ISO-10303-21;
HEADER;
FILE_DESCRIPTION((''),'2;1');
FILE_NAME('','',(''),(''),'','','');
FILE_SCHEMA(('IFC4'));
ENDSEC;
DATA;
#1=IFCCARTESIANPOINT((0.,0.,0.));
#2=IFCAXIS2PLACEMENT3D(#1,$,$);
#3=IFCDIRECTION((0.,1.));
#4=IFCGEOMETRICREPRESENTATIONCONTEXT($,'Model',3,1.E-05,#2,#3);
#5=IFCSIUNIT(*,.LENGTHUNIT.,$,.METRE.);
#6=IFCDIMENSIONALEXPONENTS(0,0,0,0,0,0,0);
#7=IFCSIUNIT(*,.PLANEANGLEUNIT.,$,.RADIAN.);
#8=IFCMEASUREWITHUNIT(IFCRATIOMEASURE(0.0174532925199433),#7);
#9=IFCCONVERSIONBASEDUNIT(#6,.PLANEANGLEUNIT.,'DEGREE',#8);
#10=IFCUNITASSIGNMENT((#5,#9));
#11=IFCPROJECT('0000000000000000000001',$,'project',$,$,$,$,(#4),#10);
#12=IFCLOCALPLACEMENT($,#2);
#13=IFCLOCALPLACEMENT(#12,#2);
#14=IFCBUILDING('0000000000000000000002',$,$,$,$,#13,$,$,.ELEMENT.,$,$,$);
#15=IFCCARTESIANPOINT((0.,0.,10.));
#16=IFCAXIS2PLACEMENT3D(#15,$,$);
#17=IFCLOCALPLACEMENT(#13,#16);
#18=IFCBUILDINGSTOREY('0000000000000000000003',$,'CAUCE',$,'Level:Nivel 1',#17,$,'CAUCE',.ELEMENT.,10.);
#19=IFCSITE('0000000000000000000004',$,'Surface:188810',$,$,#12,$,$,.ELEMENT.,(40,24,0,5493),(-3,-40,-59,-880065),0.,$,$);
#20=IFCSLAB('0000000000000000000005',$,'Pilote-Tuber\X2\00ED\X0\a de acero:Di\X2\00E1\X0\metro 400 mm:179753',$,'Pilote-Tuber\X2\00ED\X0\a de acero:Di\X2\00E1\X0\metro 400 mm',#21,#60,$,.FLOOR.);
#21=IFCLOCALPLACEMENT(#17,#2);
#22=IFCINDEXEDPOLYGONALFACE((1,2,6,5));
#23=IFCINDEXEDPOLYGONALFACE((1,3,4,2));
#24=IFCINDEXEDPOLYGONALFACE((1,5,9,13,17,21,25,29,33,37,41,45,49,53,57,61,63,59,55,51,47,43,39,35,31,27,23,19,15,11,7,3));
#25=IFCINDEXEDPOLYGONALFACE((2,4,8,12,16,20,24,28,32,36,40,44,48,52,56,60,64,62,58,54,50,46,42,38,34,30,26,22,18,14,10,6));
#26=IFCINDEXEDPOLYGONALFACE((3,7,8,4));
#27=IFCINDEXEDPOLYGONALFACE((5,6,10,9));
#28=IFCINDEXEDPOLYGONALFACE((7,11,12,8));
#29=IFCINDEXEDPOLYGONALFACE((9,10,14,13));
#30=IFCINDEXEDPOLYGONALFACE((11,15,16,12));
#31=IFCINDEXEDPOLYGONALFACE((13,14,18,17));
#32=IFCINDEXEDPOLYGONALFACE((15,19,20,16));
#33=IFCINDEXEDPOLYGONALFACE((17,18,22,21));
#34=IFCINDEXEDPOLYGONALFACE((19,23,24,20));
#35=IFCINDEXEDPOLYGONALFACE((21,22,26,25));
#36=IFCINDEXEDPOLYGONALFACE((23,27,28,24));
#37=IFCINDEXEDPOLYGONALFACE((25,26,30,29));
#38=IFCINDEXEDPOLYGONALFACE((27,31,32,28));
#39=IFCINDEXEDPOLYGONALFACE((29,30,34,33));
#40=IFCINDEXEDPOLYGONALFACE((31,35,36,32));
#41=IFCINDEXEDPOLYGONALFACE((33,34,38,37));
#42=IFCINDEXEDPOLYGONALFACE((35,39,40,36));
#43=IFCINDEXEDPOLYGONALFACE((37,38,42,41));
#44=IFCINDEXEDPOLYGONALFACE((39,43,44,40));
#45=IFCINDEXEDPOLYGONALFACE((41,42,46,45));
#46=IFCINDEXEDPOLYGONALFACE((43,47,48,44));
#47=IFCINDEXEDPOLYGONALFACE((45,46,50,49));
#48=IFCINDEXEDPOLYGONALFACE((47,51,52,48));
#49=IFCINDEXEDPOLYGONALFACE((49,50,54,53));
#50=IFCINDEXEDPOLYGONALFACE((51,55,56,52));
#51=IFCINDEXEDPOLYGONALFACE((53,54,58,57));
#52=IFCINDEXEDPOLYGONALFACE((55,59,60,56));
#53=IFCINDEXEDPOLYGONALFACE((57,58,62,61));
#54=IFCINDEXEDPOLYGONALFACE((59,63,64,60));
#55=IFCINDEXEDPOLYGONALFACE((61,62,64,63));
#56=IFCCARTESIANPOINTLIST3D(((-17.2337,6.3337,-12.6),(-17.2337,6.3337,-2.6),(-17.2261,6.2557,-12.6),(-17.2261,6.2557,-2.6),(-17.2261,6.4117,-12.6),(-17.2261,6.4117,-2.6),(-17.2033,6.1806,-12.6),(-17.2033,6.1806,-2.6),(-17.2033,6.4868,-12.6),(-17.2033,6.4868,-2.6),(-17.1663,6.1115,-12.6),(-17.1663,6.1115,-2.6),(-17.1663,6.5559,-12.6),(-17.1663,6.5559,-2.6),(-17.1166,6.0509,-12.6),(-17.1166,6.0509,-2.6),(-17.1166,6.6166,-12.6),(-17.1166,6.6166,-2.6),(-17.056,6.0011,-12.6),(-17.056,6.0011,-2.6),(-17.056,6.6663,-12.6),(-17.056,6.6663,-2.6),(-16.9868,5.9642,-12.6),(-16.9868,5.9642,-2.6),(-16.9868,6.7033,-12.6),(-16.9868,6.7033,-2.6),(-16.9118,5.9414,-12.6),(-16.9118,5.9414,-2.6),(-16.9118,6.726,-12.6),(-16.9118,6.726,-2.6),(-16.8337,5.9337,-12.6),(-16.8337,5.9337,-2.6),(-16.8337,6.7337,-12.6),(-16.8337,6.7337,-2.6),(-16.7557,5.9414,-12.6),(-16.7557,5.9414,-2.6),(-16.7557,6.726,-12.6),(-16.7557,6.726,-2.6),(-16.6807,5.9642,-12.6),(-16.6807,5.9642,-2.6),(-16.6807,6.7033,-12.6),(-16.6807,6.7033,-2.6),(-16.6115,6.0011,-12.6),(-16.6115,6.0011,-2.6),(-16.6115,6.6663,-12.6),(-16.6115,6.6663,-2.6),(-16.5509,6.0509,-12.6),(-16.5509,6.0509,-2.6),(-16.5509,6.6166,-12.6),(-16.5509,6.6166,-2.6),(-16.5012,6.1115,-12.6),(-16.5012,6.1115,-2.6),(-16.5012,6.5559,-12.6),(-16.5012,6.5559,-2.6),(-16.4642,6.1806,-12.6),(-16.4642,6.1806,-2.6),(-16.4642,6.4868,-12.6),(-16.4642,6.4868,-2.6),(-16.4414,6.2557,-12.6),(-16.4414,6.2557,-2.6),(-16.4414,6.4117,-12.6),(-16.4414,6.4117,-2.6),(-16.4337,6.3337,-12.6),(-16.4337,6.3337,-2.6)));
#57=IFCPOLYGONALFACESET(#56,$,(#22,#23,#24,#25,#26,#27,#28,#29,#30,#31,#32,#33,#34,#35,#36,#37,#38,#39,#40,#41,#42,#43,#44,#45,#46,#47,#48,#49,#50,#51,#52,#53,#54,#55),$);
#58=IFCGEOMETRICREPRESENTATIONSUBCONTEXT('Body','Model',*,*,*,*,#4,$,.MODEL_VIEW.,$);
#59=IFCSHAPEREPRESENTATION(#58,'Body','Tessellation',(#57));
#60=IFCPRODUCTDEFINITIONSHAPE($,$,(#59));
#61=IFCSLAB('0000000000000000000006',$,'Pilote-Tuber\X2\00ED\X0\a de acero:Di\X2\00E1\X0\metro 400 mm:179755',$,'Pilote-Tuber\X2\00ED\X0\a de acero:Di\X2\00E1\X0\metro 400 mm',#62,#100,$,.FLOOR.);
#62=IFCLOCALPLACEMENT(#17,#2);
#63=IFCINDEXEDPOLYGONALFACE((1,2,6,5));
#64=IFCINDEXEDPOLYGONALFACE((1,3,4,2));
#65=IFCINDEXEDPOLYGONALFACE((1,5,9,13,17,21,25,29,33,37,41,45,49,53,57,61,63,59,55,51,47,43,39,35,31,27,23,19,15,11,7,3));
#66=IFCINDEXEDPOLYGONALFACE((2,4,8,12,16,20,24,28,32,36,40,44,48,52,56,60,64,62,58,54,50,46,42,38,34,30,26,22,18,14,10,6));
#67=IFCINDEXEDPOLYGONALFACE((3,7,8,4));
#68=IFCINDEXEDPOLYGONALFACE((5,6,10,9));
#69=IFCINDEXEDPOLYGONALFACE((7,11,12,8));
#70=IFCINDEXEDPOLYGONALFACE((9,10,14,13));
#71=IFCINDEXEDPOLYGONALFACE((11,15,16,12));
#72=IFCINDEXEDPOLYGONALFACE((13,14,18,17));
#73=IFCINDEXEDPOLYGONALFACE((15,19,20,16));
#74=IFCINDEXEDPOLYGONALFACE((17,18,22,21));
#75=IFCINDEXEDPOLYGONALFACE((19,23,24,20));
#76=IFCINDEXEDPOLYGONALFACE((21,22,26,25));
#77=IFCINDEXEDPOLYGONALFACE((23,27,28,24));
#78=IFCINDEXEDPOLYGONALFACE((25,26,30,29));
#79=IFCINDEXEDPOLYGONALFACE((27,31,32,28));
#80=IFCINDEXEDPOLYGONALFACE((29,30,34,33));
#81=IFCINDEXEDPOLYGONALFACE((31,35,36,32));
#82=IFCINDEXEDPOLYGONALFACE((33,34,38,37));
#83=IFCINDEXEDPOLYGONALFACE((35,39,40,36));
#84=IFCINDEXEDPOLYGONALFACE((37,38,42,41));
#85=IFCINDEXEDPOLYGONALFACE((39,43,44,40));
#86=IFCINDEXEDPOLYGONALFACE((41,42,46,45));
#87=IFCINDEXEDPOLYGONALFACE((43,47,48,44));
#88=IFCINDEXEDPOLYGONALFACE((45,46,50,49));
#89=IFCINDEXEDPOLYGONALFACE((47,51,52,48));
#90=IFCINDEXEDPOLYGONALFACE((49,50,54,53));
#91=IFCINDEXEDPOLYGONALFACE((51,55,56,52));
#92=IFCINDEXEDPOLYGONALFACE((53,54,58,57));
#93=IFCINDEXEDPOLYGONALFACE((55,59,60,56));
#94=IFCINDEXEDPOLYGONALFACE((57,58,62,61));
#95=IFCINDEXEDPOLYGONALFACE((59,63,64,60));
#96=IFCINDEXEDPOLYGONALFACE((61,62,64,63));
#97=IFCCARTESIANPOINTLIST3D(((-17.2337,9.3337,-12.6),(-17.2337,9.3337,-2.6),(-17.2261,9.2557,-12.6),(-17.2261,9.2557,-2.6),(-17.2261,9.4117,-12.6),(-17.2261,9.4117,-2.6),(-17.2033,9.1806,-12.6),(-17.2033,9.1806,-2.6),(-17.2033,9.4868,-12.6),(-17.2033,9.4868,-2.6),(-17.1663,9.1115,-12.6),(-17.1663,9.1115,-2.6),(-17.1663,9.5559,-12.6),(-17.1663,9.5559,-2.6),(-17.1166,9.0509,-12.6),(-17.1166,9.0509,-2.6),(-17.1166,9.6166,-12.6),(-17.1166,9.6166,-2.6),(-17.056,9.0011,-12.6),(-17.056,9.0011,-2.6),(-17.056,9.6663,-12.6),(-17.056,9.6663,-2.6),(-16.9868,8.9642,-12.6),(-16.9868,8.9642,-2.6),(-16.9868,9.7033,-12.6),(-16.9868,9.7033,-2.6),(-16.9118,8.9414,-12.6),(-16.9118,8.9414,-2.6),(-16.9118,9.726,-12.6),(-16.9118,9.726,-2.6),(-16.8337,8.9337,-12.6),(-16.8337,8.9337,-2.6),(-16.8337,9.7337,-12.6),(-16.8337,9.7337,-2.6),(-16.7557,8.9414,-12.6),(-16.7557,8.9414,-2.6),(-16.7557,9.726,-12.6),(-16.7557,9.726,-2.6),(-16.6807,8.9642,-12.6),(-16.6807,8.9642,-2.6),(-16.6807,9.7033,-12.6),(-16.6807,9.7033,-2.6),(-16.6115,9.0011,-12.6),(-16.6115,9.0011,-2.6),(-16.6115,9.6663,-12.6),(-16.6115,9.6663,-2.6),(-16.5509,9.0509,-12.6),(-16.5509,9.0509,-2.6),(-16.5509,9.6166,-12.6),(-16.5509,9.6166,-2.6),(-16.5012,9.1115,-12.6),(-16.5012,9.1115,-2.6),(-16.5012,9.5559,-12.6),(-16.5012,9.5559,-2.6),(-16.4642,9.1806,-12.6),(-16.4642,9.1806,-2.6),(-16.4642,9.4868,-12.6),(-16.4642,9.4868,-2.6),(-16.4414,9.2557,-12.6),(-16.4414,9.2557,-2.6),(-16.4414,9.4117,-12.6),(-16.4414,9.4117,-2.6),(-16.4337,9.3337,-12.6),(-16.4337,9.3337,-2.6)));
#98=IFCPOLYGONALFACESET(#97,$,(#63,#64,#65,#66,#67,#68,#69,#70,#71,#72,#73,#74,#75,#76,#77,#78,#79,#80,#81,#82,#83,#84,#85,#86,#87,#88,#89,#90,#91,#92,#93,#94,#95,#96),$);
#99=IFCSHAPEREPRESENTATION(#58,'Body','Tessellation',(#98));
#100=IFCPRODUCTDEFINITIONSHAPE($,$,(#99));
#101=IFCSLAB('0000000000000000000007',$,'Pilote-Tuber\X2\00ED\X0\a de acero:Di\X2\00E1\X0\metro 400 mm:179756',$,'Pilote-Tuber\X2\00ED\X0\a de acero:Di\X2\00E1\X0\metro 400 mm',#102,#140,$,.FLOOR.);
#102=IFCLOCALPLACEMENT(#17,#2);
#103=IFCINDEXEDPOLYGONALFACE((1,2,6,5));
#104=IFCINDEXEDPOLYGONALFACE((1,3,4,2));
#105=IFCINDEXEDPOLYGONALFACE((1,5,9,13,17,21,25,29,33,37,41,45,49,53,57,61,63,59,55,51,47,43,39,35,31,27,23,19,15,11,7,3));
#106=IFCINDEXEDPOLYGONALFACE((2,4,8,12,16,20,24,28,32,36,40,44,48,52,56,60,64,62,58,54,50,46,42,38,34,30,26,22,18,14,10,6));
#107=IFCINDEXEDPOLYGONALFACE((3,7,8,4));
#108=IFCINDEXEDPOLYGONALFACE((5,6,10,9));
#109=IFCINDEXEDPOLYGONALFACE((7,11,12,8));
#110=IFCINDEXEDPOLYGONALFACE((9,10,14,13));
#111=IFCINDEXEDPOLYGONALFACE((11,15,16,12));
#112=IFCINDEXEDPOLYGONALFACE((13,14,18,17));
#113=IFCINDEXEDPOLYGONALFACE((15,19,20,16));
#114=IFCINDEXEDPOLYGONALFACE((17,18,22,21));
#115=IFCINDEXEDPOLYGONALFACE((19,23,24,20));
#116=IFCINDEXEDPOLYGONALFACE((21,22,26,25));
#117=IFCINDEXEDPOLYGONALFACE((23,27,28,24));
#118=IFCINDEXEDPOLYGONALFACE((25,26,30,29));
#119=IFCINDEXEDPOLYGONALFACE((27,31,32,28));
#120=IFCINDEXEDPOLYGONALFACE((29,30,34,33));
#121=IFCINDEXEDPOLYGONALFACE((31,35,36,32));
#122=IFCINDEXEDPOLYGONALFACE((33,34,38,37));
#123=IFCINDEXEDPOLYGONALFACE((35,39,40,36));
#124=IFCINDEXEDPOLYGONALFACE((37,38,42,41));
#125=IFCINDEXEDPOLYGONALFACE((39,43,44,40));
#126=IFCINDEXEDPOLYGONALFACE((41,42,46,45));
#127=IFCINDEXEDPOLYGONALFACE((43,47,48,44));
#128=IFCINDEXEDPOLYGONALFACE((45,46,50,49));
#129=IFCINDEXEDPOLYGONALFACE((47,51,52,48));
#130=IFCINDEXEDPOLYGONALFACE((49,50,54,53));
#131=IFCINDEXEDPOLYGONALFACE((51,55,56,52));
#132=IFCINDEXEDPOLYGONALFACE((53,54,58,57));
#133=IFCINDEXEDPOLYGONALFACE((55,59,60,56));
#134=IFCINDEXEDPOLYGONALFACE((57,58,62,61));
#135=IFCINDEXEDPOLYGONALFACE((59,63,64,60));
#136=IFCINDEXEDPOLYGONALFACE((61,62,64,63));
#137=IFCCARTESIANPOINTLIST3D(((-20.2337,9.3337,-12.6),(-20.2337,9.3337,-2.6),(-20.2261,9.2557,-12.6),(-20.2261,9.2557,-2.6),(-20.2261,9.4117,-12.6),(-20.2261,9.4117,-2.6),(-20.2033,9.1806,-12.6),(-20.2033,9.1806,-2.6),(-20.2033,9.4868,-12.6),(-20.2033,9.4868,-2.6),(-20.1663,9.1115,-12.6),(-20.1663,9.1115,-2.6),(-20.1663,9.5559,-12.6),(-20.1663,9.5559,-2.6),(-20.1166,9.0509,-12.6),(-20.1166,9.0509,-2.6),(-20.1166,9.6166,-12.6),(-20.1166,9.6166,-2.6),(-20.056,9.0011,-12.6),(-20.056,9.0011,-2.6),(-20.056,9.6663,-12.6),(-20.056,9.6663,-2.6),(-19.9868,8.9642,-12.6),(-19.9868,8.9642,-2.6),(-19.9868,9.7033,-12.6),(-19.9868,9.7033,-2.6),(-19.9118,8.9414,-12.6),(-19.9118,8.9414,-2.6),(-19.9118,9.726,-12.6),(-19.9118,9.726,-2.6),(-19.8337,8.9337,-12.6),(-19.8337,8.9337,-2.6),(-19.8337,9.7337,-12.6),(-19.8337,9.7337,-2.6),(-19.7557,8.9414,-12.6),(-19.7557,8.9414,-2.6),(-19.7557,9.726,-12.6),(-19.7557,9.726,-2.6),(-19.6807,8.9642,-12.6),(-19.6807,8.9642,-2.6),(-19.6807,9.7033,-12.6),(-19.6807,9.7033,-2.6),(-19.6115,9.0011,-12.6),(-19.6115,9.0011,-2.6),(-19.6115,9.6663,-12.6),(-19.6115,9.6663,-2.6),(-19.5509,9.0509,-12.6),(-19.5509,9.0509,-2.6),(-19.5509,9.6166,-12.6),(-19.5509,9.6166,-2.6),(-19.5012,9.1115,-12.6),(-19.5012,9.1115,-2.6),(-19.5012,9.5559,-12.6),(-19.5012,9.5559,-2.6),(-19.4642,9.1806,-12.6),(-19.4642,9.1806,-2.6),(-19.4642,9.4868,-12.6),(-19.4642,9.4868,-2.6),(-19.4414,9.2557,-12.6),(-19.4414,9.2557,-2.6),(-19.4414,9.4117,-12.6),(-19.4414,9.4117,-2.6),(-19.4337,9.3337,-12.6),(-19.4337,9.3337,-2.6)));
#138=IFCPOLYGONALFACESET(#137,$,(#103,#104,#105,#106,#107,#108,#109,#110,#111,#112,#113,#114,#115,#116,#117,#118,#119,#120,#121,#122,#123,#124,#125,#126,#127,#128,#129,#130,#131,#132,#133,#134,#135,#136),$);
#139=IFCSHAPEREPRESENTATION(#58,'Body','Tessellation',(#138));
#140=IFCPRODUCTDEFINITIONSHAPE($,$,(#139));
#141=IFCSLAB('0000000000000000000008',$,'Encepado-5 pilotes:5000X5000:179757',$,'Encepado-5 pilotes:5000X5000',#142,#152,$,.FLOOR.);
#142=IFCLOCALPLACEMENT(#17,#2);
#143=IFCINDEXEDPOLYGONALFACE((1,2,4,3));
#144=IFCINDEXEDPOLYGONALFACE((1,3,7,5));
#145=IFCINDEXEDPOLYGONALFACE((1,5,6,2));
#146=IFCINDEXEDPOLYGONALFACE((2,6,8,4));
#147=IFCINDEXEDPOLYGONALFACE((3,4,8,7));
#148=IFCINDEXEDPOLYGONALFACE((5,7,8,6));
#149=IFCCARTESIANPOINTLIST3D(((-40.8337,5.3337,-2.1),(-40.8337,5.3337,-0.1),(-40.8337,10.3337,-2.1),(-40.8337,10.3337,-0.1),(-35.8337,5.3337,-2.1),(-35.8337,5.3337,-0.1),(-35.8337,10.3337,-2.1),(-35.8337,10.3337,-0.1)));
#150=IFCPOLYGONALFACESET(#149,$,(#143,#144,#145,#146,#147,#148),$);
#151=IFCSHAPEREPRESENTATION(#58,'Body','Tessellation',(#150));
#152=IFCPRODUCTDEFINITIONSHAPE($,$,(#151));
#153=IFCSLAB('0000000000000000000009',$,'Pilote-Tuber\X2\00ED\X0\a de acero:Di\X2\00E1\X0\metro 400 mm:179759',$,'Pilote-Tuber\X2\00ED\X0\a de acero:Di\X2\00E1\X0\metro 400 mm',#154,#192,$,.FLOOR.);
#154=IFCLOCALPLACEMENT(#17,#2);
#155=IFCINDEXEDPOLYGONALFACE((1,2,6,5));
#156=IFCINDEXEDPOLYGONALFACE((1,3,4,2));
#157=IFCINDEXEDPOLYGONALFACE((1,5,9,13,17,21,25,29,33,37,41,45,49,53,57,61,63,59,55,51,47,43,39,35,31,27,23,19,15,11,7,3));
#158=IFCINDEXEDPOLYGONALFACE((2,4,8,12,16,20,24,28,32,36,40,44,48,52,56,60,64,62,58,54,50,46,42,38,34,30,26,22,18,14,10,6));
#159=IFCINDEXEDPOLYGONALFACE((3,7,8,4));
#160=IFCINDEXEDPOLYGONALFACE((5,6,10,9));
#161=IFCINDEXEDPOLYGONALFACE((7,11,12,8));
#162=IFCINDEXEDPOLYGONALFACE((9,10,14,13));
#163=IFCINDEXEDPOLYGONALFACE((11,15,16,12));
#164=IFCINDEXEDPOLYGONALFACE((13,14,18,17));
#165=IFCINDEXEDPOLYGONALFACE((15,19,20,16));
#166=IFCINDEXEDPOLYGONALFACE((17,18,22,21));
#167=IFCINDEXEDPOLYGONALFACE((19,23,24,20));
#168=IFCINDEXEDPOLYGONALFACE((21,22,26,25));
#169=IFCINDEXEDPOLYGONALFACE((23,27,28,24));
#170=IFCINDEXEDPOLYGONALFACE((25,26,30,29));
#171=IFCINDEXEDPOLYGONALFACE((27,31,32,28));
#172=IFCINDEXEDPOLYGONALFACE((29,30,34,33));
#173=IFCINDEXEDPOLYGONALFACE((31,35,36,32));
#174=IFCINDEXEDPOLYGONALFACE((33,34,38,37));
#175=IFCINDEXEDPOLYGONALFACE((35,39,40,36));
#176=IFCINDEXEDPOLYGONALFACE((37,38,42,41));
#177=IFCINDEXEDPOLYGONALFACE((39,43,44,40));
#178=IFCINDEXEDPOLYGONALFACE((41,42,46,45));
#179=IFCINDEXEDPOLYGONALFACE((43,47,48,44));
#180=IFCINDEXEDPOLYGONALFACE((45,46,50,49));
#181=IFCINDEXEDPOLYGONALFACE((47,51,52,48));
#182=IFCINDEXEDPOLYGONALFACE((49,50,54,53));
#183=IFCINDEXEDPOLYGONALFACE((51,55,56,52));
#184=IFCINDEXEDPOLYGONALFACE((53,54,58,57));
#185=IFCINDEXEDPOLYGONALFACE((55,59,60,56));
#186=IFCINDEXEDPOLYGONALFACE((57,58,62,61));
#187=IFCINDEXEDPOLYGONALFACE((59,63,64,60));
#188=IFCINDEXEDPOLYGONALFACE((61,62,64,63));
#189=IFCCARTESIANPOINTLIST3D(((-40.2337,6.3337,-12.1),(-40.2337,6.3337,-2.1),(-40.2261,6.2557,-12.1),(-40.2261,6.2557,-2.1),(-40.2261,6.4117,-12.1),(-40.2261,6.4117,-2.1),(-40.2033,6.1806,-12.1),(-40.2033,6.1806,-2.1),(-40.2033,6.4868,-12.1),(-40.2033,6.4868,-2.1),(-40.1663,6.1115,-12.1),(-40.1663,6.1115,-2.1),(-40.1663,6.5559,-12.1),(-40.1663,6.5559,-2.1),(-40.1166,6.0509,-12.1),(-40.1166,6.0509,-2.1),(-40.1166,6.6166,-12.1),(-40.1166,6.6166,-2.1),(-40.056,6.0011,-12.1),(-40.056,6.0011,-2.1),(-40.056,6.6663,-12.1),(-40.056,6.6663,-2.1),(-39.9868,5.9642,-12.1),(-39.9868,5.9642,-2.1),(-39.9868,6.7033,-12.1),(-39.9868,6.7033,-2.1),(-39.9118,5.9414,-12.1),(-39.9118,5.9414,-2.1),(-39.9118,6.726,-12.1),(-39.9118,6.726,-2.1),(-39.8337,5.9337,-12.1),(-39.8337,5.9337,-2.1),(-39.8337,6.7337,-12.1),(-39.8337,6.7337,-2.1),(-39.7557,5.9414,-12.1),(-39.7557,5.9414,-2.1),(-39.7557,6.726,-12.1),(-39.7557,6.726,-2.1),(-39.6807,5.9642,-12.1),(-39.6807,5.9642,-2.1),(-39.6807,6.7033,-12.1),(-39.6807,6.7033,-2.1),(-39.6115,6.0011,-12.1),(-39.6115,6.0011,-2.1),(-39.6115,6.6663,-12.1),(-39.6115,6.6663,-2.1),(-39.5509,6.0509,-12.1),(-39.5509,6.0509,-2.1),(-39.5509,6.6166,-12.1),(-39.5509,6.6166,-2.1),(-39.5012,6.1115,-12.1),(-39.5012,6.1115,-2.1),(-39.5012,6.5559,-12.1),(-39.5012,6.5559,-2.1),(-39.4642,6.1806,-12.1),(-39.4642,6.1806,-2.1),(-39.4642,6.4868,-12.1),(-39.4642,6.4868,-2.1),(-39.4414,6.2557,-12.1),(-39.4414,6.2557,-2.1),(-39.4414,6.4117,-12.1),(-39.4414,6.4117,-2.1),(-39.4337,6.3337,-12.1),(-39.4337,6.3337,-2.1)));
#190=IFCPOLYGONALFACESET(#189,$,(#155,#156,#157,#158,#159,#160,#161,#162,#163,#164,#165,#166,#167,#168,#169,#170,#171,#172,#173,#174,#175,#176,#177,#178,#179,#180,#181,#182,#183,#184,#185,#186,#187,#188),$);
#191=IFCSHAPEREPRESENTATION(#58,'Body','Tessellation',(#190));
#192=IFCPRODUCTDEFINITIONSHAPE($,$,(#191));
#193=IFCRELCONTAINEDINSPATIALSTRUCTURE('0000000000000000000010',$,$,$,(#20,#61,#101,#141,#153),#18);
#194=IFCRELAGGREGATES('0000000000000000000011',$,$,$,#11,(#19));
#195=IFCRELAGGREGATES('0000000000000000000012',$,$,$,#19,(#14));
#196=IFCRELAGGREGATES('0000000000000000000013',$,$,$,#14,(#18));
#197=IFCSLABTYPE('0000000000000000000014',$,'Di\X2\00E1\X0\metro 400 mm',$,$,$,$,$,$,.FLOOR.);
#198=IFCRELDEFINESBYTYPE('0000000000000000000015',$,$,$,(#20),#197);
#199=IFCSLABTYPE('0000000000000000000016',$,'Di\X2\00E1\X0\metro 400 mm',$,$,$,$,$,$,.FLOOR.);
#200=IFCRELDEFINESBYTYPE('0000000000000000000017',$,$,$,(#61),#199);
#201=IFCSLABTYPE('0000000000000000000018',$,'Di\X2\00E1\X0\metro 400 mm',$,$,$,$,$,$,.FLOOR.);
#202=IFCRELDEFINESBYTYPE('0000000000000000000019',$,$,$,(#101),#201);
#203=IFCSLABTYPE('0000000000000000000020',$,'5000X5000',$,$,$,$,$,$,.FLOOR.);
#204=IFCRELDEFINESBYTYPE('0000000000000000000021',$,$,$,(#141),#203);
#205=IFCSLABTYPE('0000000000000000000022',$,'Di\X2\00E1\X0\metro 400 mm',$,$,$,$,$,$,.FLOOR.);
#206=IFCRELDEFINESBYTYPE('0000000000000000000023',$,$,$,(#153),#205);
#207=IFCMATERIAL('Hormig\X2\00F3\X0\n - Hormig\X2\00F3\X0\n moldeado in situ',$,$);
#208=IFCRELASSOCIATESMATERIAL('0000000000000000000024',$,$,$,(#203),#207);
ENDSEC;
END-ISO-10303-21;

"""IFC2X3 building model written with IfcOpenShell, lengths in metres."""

from ifc_helpers import new_model, entity, si_unit, converted_unit, direction, frame, frame_2d, origin, origin_2d_with_axis, place, context, subcontext, project, spatial, rectangle, circle, extrude, material, type_object, element, save


model = new_model("IFC2X3")

# Units and contexts
model_context = context("Model", 3, precision=1e-05, world=origin(), true_north=direction((0.0, 1.0)))
body_context = subcontext(model_context, "Body", "Model", "MODEL_VIEW")
ifc_project = project(units=[si_unit("LENGTHUNIT", "METRE"), converted_unit("PLANEANGLEUNIT", "DEGREE", entity("IfcRatioMeasure", 0.0174532925199433), si_unit("PLANEANGLEUNIT", "RADIAN"), dimensions=[0, 0, 0, 0, 0, 0, 0])], contexts=[model_context])

# Site, building, storey
site_placement = place(None, origin())
site = spatial("IfcSite", under=ifc_project, at=site_placement, Name="Surface:188810", CompositionType="ELEMENT", RefLatitude=(40, 24, 0, 5493), RefLongitude=(-3, -40, -59, -880065), RefElevation=0.0)
building_placement = place(site_placement, origin())
building = spatial("IfcBuilding", under=site, at=building_placement, CompositionType="ELEMENT")
storey_placement = place(building_placement, frame((0.0, 0.0, 10.0)))
storey = spatial("IfcBuildingStorey", under=building, at=storey_placement, Name="CAUCE", ObjectType="Level:Nivel 1", LongName="CAUCE", CompositionType="ELEMENT", Elevation=10.0)

# Slabs
slab_type_1 = type_object("IfcSlabType", Name="Diámetro 400 mm", PredefinedType="FLOOR")
slab_1_placement = place(storey_placement, origin())
element("IfcSlab", 1, at=slab_1_placement, inside=storey, type_object=slab_type_1, Name="Pilote-Tubería de acero:Diámetro 400 mm:179753", ObjectType="Pilote-Tubería de acero:Diámetro 400 mm", PredefinedType="FLOOR", context=body_context, shape_type="SweptSolid", body=[
    extrude(circle(Radius=0.4, at=origin_2d_with_axis()), frame((-16.8337, 6.3337, -12.6)), (0.0, 0.0, 1.0), 10.0),
])
slab_type_2 = type_object("IfcSlabType", Name="Diámetro 400 mm", PredefinedType="FLOOR")
slab_2_placement = place(storey_placement, origin())
element("IfcSlab", 2, at=slab_2_placement, inside=storey, type_object=slab_type_2, Name="Pilote-Tubería de acero:Diámetro 400 mm:179755", ObjectType="Pilote-Tubería de acero:Diámetro 400 mm", PredefinedType="FLOOR", context=body_context, shape_type="SweptSolid", body=[
    extrude(circle(Radius=0.4, at=origin_2d_with_axis()), frame((-16.8337, 9.3337, -12.6)), (0.0, 0.0, 1.0), 10.0),
])
slab_type_3 = type_object("IfcSlabType", Name="Diámetro 400 mm", PredefinedType="FLOOR")
slab_3_placement = place(storey_placement, origin())
element("IfcSlab", 3, at=slab_3_placement, inside=storey, type_object=slab_type_3, Name="Pilote-Tubería de acero:Diámetro 400 mm:179756", ObjectType="Pilote-Tubería de acero:Diámetro 400 mm", PredefinedType="FLOOR", context=body_context, shape_type="SweptSolid", body=[
    extrude(circle(Radius=0.4, at=origin_2d_with_axis()), frame((-19.8337, 9.3337, -12.6)), (0.0, 0.0, 1.0), 10.0),
])
ifc_material = material(Name="Hormigón - Hormigón moldeado in situ")
slab_type_4 = type_object("IfcSlabType", Name="5000X5000", PredefinedType="FLOOR", material=ifc_material)
slab_4_placement = place(storey_placement, origin())
element("IfcSlab", 4, at=slab_4_placement, inside=storey, type_object=slab_type_4, Name="Encepado-5 pilotes:5000X5000:179757", ObjectType="Encepado-5 pilotes:5000X5000", PredefinedType="FLOOR", context=body_context, shape_type="SweptSolid", body=[
    extrude(rectangle(XDim=5.0, YDim=5.0, at=frame_2d((0.0, 0.0), x_axis=(1.0, 0.0))), frame((-38.3337, 7.8337, -2.1), z_axis=(0.0, 0.0, 1.0), x_axis=(-1.0, 0.0, 0.0)), (0.0, 0.0, 1.0), 2.0),
])
slab_type_5 = type_object("IfcSlabType", Name="Diámetro 400 mm", PredefinedType="FLOOR")
slab_5_placement = place(storey_placement, origin())
element("IfcSlab", 5, at=slab_5_placement, inside=storey, type_object=slab_type_5, Name="Pilote-Tubería de acero:Diámetro 400 mm:179759", ObjectType="Pilote-Tubería de acero:Diámetro 400 mm", PredefinedType="FLOOR", context=body_context, shape_type="SweptSolid", body=[
    extrude(circle(Radius=0.4, at=origin_2d_with_axis()), frame((-39.8337, 6.3337, -12.1)), (0.0, 0.0, 1.0), 10.0),
])

save(model, "model.ifc")
